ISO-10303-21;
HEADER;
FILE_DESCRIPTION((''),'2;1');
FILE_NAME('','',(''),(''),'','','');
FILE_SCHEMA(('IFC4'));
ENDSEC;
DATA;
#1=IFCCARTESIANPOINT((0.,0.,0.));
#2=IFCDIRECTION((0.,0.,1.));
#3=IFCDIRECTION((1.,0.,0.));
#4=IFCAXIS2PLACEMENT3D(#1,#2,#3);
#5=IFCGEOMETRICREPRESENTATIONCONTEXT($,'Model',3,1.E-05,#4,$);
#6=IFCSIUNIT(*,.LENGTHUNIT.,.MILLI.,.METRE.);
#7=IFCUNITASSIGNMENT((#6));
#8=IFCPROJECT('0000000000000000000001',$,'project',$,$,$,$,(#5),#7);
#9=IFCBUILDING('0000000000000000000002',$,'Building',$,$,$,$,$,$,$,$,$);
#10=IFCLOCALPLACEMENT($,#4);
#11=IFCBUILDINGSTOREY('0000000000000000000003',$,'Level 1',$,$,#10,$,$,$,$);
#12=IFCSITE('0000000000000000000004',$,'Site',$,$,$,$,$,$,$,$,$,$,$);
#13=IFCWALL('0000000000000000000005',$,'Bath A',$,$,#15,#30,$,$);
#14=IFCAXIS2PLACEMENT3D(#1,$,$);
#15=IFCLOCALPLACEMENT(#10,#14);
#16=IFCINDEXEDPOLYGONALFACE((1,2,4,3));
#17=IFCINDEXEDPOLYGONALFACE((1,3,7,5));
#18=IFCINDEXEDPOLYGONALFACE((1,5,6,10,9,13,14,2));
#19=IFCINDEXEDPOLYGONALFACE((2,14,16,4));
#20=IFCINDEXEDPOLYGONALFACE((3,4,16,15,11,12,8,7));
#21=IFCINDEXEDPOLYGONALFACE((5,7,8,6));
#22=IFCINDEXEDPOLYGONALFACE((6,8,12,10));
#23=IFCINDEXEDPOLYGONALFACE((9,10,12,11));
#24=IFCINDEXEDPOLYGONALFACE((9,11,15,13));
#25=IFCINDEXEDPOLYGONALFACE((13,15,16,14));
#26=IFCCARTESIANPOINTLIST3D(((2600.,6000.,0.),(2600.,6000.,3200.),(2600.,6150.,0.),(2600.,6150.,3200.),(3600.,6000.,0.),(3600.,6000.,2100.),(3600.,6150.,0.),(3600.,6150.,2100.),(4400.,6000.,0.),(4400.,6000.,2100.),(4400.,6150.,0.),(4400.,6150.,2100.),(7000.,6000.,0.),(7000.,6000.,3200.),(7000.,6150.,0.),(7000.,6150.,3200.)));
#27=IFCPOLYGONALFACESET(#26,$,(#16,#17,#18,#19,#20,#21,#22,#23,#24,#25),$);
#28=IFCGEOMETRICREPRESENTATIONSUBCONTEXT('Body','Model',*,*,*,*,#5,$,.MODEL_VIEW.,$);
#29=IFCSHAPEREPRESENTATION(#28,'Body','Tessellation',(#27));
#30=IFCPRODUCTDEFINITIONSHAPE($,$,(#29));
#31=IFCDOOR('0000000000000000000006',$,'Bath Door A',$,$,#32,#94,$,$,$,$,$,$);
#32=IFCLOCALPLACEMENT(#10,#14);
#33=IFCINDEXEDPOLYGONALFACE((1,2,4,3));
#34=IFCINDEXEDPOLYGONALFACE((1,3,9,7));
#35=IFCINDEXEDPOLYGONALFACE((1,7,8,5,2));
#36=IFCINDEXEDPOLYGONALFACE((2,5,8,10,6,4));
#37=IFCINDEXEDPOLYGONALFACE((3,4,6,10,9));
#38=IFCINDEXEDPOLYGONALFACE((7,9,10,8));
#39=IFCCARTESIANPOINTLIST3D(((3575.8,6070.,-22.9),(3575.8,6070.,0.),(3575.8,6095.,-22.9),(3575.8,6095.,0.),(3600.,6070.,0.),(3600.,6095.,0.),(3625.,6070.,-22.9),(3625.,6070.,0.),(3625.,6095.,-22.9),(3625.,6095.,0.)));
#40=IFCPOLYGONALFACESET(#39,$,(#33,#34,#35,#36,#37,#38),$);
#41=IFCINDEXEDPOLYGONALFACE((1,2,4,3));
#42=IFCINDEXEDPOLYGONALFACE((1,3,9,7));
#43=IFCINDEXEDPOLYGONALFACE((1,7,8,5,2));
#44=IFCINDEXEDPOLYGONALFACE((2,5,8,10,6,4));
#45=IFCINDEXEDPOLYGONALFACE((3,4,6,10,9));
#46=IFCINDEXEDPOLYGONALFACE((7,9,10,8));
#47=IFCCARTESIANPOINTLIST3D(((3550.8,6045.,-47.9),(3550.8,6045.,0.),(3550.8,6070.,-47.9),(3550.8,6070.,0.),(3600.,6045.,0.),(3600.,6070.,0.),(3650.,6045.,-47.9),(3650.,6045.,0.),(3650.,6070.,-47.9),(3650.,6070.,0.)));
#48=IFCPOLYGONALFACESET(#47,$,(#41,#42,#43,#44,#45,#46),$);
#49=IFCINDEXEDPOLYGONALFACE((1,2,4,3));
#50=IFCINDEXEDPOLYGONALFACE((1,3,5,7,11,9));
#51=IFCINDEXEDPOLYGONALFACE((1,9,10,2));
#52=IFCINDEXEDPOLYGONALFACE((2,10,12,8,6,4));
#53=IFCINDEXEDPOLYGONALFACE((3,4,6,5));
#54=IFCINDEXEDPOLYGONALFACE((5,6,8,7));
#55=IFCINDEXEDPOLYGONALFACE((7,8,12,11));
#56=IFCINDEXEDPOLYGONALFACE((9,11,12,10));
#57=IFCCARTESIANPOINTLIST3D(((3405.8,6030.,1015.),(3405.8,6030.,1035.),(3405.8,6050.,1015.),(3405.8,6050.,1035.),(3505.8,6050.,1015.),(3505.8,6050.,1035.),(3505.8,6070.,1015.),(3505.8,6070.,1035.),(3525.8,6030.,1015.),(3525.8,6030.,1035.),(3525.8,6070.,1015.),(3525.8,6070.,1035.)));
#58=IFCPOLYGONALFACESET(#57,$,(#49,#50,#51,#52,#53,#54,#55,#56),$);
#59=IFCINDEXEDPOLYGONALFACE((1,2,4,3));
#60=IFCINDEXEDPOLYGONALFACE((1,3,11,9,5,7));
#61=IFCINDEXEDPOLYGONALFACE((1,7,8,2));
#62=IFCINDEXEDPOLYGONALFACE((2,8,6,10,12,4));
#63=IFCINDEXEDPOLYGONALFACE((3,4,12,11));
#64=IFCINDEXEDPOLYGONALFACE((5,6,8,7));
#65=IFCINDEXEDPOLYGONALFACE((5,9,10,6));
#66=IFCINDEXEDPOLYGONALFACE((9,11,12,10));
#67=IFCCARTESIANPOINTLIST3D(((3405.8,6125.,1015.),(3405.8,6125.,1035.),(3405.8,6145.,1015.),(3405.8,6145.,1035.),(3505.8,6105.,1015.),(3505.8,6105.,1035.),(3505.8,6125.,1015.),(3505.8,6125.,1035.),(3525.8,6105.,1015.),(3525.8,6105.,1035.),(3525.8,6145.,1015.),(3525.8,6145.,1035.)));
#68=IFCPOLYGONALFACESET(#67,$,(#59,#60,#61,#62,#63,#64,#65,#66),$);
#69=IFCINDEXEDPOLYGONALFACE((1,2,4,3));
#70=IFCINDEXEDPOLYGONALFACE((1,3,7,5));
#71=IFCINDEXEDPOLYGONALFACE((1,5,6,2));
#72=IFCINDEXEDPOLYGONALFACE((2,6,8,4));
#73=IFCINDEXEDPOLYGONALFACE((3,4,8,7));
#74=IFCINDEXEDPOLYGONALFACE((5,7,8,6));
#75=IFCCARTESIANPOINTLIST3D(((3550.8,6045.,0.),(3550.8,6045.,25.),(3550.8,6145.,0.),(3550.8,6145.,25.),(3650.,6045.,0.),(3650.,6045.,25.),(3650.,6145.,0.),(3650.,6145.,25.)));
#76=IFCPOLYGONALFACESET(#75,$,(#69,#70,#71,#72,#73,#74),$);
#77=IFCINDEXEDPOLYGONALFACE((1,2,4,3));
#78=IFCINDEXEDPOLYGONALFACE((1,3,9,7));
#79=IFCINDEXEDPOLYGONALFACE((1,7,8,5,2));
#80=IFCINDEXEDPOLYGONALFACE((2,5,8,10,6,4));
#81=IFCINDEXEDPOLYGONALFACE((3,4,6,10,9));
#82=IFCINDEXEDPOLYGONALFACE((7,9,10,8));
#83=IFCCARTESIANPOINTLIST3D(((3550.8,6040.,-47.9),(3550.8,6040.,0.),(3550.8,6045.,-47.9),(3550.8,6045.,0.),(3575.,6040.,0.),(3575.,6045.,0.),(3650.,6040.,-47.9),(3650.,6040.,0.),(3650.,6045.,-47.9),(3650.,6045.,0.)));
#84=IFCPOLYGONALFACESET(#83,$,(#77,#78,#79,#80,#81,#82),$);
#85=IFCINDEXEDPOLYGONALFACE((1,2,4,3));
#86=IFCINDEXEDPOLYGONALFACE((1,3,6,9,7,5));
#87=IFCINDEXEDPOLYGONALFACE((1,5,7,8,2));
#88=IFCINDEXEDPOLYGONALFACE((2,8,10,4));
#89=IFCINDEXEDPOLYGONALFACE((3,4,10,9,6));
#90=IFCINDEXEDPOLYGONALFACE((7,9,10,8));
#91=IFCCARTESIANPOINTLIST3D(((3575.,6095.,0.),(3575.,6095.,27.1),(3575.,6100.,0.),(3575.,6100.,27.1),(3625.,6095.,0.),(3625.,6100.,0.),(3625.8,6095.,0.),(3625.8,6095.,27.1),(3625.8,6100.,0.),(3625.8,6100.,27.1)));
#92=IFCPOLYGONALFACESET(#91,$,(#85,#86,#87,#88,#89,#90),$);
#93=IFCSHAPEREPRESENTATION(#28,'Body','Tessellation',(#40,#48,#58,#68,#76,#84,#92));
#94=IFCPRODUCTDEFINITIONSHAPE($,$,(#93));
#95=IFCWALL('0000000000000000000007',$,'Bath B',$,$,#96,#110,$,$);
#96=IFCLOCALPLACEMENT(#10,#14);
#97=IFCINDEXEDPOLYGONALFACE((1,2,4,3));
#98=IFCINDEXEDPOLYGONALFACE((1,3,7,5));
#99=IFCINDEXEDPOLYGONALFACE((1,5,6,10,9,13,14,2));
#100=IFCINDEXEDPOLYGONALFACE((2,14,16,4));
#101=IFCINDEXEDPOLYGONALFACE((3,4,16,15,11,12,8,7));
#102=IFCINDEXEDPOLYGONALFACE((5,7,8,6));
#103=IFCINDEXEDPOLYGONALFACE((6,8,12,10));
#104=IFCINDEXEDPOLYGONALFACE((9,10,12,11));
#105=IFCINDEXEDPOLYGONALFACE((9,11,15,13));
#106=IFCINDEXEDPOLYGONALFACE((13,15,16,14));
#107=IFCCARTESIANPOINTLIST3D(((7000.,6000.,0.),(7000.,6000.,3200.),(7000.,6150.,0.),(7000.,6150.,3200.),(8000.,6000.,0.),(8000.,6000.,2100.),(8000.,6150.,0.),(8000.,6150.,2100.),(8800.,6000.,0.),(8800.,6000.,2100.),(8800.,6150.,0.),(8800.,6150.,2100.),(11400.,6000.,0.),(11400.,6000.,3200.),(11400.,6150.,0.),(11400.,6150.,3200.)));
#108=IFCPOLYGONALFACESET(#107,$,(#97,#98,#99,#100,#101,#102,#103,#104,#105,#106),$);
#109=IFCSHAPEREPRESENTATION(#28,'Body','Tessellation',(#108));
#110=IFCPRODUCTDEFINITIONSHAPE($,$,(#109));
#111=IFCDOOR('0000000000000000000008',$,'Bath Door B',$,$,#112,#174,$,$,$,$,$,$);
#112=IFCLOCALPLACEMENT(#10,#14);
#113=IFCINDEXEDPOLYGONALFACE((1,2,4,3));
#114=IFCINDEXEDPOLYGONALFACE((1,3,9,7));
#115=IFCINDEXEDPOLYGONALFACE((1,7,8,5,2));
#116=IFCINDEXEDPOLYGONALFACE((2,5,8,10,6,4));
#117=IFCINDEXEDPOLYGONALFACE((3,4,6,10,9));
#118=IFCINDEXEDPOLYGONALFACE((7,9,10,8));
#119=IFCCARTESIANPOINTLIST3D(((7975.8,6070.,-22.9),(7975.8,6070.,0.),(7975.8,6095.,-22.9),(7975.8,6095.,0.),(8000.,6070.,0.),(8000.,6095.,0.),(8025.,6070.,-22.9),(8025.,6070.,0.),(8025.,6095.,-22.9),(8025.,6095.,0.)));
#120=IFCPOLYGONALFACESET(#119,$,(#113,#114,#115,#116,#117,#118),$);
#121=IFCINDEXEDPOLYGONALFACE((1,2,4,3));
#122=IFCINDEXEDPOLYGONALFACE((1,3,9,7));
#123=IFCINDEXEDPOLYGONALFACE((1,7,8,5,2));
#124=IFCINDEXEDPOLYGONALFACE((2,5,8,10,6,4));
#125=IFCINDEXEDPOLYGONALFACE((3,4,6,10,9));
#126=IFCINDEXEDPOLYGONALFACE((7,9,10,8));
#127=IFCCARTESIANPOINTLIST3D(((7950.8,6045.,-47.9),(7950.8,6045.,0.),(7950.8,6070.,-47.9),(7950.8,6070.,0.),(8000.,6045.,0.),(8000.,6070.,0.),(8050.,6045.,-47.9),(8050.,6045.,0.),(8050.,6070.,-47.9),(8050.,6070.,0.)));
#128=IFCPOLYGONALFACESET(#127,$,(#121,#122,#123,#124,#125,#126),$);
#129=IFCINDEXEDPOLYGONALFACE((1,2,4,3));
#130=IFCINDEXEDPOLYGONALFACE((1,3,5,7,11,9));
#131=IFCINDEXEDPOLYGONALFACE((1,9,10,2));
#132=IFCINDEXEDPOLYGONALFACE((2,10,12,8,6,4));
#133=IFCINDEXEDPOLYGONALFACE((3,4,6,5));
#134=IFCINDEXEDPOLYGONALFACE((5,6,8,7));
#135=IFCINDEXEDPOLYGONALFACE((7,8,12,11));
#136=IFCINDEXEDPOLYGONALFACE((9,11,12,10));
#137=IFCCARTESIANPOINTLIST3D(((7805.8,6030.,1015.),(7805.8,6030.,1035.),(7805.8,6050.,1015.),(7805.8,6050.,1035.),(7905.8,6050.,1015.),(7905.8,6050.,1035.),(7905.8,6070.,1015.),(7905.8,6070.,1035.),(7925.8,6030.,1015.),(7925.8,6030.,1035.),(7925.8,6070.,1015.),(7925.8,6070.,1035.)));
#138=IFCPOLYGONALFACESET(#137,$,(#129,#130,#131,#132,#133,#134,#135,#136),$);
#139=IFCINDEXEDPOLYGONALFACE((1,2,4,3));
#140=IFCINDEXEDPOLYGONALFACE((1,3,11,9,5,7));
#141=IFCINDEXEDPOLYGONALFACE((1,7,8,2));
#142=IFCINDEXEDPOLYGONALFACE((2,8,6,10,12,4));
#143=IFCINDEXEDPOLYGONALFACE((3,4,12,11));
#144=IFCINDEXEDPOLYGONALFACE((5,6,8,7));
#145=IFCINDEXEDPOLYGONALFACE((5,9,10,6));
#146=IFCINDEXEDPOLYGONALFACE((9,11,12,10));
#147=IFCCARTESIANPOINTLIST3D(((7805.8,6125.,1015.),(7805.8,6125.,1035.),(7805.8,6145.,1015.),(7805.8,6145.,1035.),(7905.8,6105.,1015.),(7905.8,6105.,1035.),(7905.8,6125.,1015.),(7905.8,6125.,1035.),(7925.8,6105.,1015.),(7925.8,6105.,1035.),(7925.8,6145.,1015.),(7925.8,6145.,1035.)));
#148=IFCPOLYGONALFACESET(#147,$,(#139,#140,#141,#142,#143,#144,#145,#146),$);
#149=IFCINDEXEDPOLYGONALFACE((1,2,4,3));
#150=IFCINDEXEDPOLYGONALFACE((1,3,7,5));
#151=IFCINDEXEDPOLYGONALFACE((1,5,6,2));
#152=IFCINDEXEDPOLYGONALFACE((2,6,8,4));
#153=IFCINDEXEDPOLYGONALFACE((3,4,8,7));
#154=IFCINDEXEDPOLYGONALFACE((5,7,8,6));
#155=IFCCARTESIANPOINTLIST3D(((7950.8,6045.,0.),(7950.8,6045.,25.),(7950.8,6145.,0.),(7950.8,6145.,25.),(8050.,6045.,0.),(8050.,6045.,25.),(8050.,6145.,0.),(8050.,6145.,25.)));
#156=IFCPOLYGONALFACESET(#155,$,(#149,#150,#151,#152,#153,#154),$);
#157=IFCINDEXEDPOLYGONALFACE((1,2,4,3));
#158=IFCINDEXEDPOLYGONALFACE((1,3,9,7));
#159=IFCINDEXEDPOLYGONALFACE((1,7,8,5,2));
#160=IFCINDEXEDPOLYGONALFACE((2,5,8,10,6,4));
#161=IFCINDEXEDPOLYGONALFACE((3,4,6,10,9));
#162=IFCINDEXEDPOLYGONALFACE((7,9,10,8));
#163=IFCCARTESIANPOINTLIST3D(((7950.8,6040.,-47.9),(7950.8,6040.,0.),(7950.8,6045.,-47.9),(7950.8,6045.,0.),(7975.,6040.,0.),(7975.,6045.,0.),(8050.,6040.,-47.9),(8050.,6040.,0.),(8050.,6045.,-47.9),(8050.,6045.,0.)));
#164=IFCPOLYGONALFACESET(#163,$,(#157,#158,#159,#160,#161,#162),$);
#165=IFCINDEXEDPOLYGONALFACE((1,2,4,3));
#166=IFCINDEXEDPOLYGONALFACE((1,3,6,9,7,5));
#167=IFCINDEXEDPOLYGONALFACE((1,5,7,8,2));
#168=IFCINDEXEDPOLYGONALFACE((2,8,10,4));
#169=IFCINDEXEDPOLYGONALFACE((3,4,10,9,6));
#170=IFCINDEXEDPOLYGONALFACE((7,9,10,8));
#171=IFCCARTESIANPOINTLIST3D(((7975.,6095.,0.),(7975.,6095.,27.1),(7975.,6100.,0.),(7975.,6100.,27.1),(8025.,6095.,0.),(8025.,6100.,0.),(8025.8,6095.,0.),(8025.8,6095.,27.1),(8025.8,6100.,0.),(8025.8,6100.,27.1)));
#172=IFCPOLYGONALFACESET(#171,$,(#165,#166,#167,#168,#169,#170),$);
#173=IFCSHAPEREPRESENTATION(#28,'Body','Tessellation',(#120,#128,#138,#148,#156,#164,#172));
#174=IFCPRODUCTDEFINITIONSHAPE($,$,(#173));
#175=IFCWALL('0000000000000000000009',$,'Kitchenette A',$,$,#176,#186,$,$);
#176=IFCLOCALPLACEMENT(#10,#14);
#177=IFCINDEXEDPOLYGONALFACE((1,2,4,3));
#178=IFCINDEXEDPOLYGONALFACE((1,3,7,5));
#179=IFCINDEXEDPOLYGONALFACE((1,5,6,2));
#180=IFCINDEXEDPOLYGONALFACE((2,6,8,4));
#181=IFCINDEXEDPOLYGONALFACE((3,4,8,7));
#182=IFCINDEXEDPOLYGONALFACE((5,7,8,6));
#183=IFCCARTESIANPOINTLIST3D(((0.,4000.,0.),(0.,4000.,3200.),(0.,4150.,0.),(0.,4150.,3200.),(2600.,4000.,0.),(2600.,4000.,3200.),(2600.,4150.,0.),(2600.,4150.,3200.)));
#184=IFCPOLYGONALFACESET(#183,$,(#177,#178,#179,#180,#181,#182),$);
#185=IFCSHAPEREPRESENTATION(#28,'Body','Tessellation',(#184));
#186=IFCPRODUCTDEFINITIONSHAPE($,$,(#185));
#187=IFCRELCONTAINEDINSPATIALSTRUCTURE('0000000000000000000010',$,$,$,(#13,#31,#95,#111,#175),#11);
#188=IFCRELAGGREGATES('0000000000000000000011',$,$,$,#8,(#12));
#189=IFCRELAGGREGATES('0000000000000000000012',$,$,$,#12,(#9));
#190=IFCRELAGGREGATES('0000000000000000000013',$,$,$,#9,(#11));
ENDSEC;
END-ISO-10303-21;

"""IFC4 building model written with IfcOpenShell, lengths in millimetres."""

from ifc_helpers import new_model, si_unit, frame, origin_with_axes, place, context, subcontext, project, spatial, line, indexed_curve, outline, extrude, element, fill, save


model = new_model("IFC4")

# Units and contexts
model_context = context("Model", 3, precision=1e-05, world=origin_with_axes())
body_context = subcontext(model_context, "Body", "Model", "MODEL_VIEW")
ifc_project = project(units=[si_unit("LENGTHUNIT", "METRE", prefix="MILLI")], contexts=[model_context])

# Site, building, storey
site = spatial("IfcSite", under=ifc_project, Name="Site")
building = spatial("IfcBuilding", under=site, Name="Building")
storey_placement = place(None, origin_with_axes())
storey = spatial("IfcBuildingStorey", under=building, at=storey_placement, Name="Level 1")

# Walls, openings, doors
wall_1_placement = place(storey_placement, frame((2600.0, 6000.0, 0.0), z_axis=(0.0, 0.0, 1.0), x_axis=(1.0, 0.0, 0.0)))
wall_1 = element("IfcWall", 1, at=wall_1_placement, inside=storey, Name="Bath A", context=body_context, shape_type="SweptSolid", body=[
    extrude(outline(indexed_curve([(0.0, 0.0), (0.0, 150.0), (4400.0, 150.0), (4400.0, 0.0), (0.0, 0.0)], self_intersect=False)), origin_with_axes(), (0.0, 0.0, 1.0), 3200.0),
])
opening_1_placement = place(wall_1_placement, frame((1000.0, -100.0, 0.0), z_axis=(0.0, 0.0, 1.0), x_axis=(1.0, 0.0, 0.0)))
opening_1 = element("IfcOpeningElement", 2, at=opening_1_placement, cuts=wall_1, context=body_context, shape_type="SweptSolid", body=[
    extrude(outline(indexed_curve([(0.0, 0.0), (0.0, 350.0), (800.0, 350.0), (800.0, 0.0), (0.0, 0.0)], self_intersect=False)), origin_with_axes(), (0.0, 0.0, 1.0), 2100.0),
])
door_1_placement = place(opening_1_placement, frame((0.0, 145.0, 0.0), z_axis=(0.0, 0.0, 1.0), x_axis=(1.0, 0.0, 0.0)))
door_1 = element("IfcDoor", 3, at=door_1_placement, inside=storey, Name="Bath Door A", context=body_context, shape_type="SweptSolid", body=[
    extrude(outline(indexed_curve([(0.0, 0.0), (0.0, 2.1), (0.8, 2.1), (0.8, 0.0), (-24.2, 0.0), (-24.2, -22.9), (25.0, -22.9), (25.0, 0.0)], segments=[line(1, 2, 3, 4, 5, 6, 7, 8, 1)])), frame((0.0, 25.0, 0.0), z_axis=(0.0, -1.0, 0.0), x_axis=(1.0, 0.0, 0.0)), (0.0, 0.0, -1.0), 25.0),
    extrude(outline(indexed_curve([(0.0, 0.0), (0.0, 2.1), (0.8, 2.1), (0.8, 0.0), (-49.2, 0.0), (-49.2, -47.9), (50.0, -47.9), (50.0, 0.0)], segments=[line(1, 2, 3, 4, 5, 6, 7, 8, 1)])), frame((0.0, 0.0, 0.0), z_axis=(0.0, -1.0, 0.0), x_axis=(1.0, 0.0, 0.0)), (0.0, 0.0, -1.0), 25.0),
    extrude(outline(indexed_curve([(0.0, 0.0), (-49.2, 0.0), (-49.2, 35.0), (0.0, 35.0)], segments=[line(1, 2, 3, 4, 1)])), frame((25.0, 25.0, 25.0), z_axis=(0.0, 0.0, 1.0), x_axis=(1.0, 0.0, 0.0)), (0.0, 0.0, 1.0), -47.9),
    extrude(outline(indexed_curve([(0.0, 0.0), (0.0, -40.0), (-120.0, -40.0), (-120.0, -20.0), (-20.0, -20.0), (-20.0, 0.0)], segments=[line(1, 2, 3, 4, 5, 6, 1)])), frame((-74.2, 25.0, 1015.0), z_axis=(0.0, 0.0, 1.0), x_axis=(1.0, 0.0, 0.0)), (0.0, 0.0, 1.0), 20.0),
    extrude(outline(indexed_curve([(0.0, 0.0), (0.0, 40.0), (-120.0, 40.0), (-120.0, 20.0), (-20.0, 20.0), (-20.0, 0.0)], segments=[line(1, 2, 3, 4, 5, 6, 1)])), frame((-74.2, 60.0, 1015.0), z_axis=(0.0, 0.0, 1.0), x_axis=(1.0, 0.0, 0.0)), (0.0, 0.0, 1.0), 20.0),
    extrude(outline(indexed_curve([(0.0, 0.0), (-99.2, 0.0), (-99.2, 100.0), (0.0, 100.0)], segments=[line(1, 2, 3, 4, 1)])), frame((50.0, 0.0, 0.0), z_axis=(0.0, 0.0, 1.0), x_axis=(1.0, 0.0, 0.0)), (0.0, 0.0, 1.0), 25.0),
    extrude(outline(indexed_curve([(0.0, 0.0), (0.0, 27.1), (50.8, 27.1), (50.8, 0.0), (-24.2, 0.0), (-24.2, -47.9), (75.0, -47.9), (75.0, 0.0)], segments=[line(1, 2, 3, 4, 5, 6, 7, 8, 1)])), frame((-25.0, -5.0, 0.0), z_axis=(0.0, -1.0, 0.0), x_axis=(1.0, 0.0, 0.0)), (0.0, 0.0, -1.0), 5.0),
    extrude(outline(indexed_curve([(0.0, 0.0), (0.0, 27.1), (50.8, 27.1), (50.8, 0.0), (0.8, 0.0), (0.8, -22.9), (50.0, -22.9), (50.0, 0.0)], segments=[line(1, 2, 3, 4, 5, 6, 7, 8, 1)])), frame((-25.0, 50.0, 0.0), z_axis=(0.0, -1.0, 0.0), x_axis=(1.0, 0.0, 0.0)), (0.0, 0.0, -1.0), 5.0),
])
fill(opening_1, door_1)
wall_2_placement = place(storey_placement, frame((7000.0, 6000.0, 0.0), z_axis=(0.0, 0.0, 1.0), x_axis=(1.0, 0.0, 0.0)))
wall_2 = element("IfcWall", 4, at=wall_2_placement, inside=storey, Name="Bath B", context=body_context, shape_type="SweptSolid", body=[
    extrude(outline(indexed_curve([(0.0, 0.0), (0.0, 150.0), (4400.0, 150.0), (4400.0, 0.0), (0.0, 0.0)], self_intersect=False)), origin_with_axes(), (0.0, 0.0, 1.0), 3200.0),
])
opening_2_placement = place(wall_2_placement, frame((1000.0, -100.0, 0.0), z_axis=(0.0, 0.0, 1.0), x_axis=(1.0, 0.0, 0.0)))
opening_2 = element("IfcOpeningElement", 5, at=opening_2_placement, cuts=wall_2, context=body_context, shape_type="SweptSolid", body=[
    extrude(outline(indexed_curve([(0.0, 0.0), (0.0, 350.0), (800.0, 350.0), (800.0, 0.0), (0.0, 0.0)], self_intersect=False)), origin_with_axes(), (0.0, 0.0, 1.0), 2100.0),
])
door_2_placement = place(opening_2_placement, frame((0.0, 145.0, 0.0), z_axis=(0.0, 0.0, 1.0), x_axis=(1.0, 0.0, 0.0)))
door_2 = element("IfcDoor", 6, at=door_2_placement, inside=storey, Name="Bath Door B", context=body_context, shape_type="SweptSolid", body=[
    extrude(outline(indexed_curve([(0.0, 0.0), (0.0, 2.1), (0.8, 2.1), (0.8, 0.0), (-24.2, 0.0), (-24.2, -22.9), (25.0, -22.9), (25.0, 0.0)], segments=[line(1, 2, 3, 4, 5, 6, 7, 8, 1)])), frame((0.0, 25.0, 0.0), z_axis=(0.0, -1.0, 0.0), x_axis=(1.0, 0.0, 0.0)), (0.0, 0.0, -1.0), 25.0),
    extrude(outline(indexed_curve([(0.0, 0.0), (0.0, 2.1), (0.8, 2.1), (0.8, 0.0), (-49.2, 0.0), (-49.2, -47.9), (50.0, -47.9), (50.0, 0.0)], segments=[line(1, 2, 3, 4, 5, 6, 7, 8, 1)])), frame((0.0, 0.0, 0.0), z_axis=(0.0, -1.0, 0.0), x_axis=(1.0, 0.0, 0.0)), (0.0, 0.0, -1.0), 25.0),
    extrude(outline(indexed_curve([(0.0, 0.0), (-49.2, 0.0), (-49.2, 35.0), (0.0, 35.0)], segments=[line(1, 2, 3, 4, 1)])), frame((25.0, 25.0, 25.0), z_axis=(0.0, 0.0, 1.0), x_axis=(1.0, 0.0, 0.0)), (0.0, 0.0, 1.0), -47.9),
    extrude(outline(indexed_curve([(0.0, 0.0), (0.0, -40.0), (-120.0, -40.0), (-120.0, -20.0), (-20.0, -20.0), (-20.0, 0.0)], segments=[line(1, 2, 3, 4, 5, 6, 1)])), frame((-74.2, 25.0, 1015.0), z_axis=(0.0, 0.0, 1.0), x_axis=(1.0, 0.0, 0.0)), (0.0, 0.0, 1.0), 20.0),
    extrude(outline(indexed_curve([(0.0, 0.0), (0.0, 40.0), (-120.0, 40.0), (-120.0, 20.0), (-20.0, 20.0), (-20.0, 0.0)], segments=[line(1, 2, 3, 4, 5, 6, 1)])), frame((-74.2, 60.0, 1015.0), z_axis=(0.0, 0.0, 1.0), x_axis=(1.0, 0.0, 0.0)), (0.0, 0.0, 1.0), 20.0),
    extrude(outline(indexed_curve([(0.0, 0.0), (-99.2, 0.0), (-99.2, 100.0), (0.0, 100.0)], segments=[line(1, 2, 3, 4, 1)])), frame((50.0, 0.0, 0.0), z_axis=(0.0, 0.0, 1.0), x_axis=(1.0, 0.0, 0.0)), (0.0, 0.0, 1.0), 25.0),
    extrude(outline(indexed_curve([(0.0, 0.0), (0.0, 27.1), (50.8, 27.1), (50.8, 0.0), (-24.2, 0.0), (-24.2, -47.9), (75.0, -47.9), (75.0, 0.0)], segments=[line(1, 2, 3, 4, 5, 6, 7, 8, 1)])), frame((-25.0, -5.0, 0.0), z_axis=(0.0, -1.0, 0.0), x_axis=(1.0, 0.0, 0.0)), (0.0, 0.0, -1.0), 5.0),
    extrude(outline(indexed_curve([(0.0, 0.0), (0.0, 27.1), (50.8, 27.1), (50.8, 0.0), (0.8, 0.0), (0.8, -22.9), (50.0, -22.9), (50.0, 0.0)], segments=[line(1, 2, 3, 4, 5, 6, 7, 8, 1)])), frame((-25.0, 50.0, 0.0), z_axis=(0.0, -1.0, 0.0), x_axis=(1.0, 0.0, 0.0)), (0.0, 0.0, -1.0), 5.0),
])
fill(opening_2, door_2)

# Wall
wall_3_placement = place(storey_placement, frame((0.0, 4000.0, 0.0), z_axis=(0.0, 0.0, 1.0), x_axis=(1.0, 0.0, 0.0)))
element("IfcWall", 7, at=wall_3_placement, inside=storey, Name="Kitchenette A", context=body_context, shape_type="SweptSolid", body=[
    extrude(outline(indexed_curve([(0.0, 0.0), (0.0, 150.0), (2600.0, 150.0), (2600.0, 0.0), (0.0, 0.0)], self_intersect=False)), origin_with_axes(), (0.0, 0.0, 1.0), 3200.0),
])

save(model, "model.ifc")
